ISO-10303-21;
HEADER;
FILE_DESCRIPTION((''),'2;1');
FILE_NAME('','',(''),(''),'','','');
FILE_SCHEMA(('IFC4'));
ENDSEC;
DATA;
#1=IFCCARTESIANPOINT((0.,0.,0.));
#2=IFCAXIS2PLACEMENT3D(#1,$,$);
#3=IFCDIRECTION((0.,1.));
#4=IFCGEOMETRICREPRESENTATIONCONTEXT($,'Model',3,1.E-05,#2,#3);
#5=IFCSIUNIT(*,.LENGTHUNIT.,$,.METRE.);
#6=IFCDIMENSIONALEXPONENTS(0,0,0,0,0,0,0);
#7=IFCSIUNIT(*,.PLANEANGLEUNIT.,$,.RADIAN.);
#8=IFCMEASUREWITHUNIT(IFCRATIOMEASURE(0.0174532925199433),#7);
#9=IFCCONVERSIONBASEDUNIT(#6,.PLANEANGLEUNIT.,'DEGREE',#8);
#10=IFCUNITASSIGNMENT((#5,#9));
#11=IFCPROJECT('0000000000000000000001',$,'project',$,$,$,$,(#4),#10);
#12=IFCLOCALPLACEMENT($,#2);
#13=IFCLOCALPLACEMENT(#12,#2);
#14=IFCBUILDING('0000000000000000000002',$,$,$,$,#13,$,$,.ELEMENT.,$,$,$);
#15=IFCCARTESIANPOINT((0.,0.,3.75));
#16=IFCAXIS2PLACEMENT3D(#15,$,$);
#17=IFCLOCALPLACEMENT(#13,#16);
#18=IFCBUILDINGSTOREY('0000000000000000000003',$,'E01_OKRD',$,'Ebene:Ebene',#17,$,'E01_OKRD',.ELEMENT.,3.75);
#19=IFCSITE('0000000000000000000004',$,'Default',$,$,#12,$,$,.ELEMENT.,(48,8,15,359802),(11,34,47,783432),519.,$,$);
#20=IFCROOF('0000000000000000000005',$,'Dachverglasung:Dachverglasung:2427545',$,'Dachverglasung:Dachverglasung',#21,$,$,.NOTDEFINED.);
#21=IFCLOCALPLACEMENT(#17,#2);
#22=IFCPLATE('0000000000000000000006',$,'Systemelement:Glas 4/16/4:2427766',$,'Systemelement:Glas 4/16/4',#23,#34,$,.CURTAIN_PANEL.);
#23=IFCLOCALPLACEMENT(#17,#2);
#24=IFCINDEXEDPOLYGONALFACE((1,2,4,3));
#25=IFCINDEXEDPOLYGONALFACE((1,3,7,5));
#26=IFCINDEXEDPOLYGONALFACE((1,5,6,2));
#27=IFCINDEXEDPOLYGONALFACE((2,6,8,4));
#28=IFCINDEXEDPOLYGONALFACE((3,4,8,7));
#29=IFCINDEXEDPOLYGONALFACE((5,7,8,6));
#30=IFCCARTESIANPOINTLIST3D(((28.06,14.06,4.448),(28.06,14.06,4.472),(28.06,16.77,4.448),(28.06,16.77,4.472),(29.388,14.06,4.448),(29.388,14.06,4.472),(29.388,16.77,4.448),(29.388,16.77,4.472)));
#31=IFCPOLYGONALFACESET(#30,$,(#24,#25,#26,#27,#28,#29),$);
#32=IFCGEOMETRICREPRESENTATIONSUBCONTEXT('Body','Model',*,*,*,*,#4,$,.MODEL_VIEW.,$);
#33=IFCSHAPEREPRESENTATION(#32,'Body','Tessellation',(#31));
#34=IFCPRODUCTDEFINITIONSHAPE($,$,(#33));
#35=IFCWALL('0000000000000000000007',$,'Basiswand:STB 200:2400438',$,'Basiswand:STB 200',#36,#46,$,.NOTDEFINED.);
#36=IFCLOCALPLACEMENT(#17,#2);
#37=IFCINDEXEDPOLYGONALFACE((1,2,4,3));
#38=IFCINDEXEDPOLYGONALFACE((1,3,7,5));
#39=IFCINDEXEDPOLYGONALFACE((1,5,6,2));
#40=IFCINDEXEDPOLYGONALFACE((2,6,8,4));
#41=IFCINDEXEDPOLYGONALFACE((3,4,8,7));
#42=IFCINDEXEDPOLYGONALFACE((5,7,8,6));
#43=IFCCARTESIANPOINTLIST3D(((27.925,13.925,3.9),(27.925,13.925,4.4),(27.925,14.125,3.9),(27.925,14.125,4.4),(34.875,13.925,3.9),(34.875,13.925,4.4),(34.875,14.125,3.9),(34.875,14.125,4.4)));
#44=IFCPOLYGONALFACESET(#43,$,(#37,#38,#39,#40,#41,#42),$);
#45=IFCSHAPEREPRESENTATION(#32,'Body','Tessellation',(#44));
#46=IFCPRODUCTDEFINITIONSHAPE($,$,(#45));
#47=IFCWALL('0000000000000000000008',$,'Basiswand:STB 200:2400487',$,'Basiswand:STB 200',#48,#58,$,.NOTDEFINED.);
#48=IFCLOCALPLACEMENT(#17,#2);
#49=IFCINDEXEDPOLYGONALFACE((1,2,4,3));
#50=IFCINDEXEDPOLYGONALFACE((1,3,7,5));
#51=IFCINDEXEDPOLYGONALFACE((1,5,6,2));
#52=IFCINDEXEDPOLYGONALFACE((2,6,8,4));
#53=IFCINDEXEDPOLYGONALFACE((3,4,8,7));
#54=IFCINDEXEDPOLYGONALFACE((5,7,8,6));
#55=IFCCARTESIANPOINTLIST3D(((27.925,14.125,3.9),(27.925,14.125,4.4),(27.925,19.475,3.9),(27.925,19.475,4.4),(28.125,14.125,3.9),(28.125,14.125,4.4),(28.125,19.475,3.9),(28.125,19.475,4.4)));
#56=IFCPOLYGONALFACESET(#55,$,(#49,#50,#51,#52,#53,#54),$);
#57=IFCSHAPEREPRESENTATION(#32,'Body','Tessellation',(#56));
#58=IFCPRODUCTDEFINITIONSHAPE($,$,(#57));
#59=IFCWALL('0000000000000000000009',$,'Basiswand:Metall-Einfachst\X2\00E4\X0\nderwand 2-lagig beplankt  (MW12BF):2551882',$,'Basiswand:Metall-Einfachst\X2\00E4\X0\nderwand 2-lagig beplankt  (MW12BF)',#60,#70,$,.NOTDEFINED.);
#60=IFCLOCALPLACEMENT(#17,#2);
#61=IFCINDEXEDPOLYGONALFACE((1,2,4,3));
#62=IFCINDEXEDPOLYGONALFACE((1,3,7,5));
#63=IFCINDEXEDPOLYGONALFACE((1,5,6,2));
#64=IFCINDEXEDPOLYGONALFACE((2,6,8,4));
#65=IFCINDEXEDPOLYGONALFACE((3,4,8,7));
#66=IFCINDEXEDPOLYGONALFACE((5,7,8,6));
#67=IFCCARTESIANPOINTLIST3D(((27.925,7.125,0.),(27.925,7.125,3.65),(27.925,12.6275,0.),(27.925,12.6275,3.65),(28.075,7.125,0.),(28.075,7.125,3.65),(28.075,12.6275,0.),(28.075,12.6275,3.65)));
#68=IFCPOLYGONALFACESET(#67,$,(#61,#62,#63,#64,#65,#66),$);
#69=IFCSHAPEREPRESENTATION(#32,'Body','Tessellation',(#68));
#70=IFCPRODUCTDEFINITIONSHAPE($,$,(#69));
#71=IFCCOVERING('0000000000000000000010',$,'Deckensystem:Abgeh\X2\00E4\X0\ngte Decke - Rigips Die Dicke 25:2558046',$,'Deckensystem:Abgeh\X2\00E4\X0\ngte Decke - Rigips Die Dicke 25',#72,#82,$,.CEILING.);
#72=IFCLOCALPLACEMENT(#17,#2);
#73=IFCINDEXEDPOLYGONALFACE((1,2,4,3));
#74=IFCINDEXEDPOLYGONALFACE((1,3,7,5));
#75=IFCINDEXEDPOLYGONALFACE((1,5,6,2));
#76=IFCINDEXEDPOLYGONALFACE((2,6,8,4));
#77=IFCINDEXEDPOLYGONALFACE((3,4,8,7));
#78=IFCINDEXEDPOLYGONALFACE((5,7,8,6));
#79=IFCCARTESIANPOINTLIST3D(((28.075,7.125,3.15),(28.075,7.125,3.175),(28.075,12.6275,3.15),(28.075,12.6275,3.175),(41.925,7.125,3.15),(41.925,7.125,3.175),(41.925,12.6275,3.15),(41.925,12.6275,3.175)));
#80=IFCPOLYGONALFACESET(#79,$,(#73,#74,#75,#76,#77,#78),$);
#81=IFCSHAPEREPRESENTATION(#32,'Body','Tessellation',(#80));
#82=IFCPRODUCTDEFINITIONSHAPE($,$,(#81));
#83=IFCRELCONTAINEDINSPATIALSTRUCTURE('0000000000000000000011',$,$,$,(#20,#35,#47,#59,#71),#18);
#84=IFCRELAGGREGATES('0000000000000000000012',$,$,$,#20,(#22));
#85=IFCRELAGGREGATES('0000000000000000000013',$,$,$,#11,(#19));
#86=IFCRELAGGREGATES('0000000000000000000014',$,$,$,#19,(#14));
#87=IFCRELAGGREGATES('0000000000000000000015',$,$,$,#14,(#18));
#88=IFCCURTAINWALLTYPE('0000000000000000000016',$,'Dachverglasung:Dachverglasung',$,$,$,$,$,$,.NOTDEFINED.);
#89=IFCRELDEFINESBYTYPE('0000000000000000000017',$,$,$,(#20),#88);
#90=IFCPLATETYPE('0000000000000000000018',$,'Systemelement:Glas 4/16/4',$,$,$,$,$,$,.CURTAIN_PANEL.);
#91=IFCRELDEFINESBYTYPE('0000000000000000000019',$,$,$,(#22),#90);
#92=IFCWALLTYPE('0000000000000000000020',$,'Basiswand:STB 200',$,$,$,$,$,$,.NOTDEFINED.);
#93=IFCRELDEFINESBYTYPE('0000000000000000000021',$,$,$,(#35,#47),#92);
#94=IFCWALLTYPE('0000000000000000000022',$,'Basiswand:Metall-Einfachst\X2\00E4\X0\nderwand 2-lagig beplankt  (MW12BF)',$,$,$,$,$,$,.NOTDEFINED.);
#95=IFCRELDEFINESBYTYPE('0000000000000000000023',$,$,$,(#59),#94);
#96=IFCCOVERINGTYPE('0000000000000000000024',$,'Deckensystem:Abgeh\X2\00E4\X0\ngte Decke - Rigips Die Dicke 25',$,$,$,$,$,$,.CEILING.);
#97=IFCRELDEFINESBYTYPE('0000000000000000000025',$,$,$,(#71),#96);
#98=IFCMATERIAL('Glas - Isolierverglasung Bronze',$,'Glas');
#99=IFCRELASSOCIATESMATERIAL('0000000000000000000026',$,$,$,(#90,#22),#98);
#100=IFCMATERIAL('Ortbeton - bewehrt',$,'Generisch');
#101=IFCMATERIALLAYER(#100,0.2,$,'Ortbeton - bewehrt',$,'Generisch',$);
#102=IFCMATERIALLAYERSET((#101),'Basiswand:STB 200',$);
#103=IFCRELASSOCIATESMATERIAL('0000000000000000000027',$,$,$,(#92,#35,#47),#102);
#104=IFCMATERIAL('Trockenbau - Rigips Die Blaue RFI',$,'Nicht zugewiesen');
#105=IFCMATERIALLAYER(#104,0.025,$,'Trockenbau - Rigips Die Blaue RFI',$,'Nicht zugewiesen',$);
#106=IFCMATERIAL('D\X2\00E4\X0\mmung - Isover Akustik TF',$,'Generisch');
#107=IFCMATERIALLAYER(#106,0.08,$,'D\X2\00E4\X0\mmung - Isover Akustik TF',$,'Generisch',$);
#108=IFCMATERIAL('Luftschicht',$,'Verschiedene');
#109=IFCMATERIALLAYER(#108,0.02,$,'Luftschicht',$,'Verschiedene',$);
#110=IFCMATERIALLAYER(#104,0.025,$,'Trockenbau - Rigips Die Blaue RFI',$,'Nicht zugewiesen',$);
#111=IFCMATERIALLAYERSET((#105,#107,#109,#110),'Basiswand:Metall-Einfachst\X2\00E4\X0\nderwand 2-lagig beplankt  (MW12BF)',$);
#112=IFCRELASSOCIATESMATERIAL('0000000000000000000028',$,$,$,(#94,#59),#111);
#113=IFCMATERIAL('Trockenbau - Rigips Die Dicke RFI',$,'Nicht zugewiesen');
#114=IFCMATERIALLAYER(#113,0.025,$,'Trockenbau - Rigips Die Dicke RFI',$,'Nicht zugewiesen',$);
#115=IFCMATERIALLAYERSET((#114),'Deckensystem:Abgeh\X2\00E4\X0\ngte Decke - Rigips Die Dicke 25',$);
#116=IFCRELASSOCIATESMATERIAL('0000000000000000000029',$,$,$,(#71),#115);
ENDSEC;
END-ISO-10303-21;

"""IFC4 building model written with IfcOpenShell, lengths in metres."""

from ifc_helpers import new_model, entity, si_unit, converted_unit, direction, frame, frame_2d, origin, origin_2d_with_axis, place, context, subcontext, project, spatial, rectangle, extrude, shape, source, transform, mapped, material, layer, layer_set, layer_usage, type_object, type_shapes, element, aggregate, save


model = new_model("IFC4")

# Units and contexts
model_context = context("Model", 3, precision=1e-05, world=origin(), true_north=direction((0.0, 1.0)))
body_context = subcontext(model_context, "Body", "Model", "MODEL_VIEW")
footprint_context = subcontext(model_context, "FootPrint", "Model", "MODEL_VIEW")
ifc_project = project(units=[si_unit("LENGTHUNIT", "METRE"), converted_unit("PLANEANGLEUNIT", "DEGREE", entity("IfcRatioMeasure", 0.0174532925199433), si_unit("PLANEANGLEUNIT", "RADIAN"), dimensions=[0, 0, 0, 0, 0, 0, 0])], contexts=[model_context])

# Site, building, storey
site_placement = place(None, frame((0.0, 0.0, 0.0)))
site = spatial("IfcSite", under=ifc_project, at=site_placement, Name="Default", CompositionType="ELEMENT", RefLatitude=(48, 8, 15, 359802), RefLongitude=(11, 34, 47, 783432), RefElevation=519.0)
building_placement = place(site_placement, origin())
building = spatial("IfcBuilding", under=site, at=building_placement, CompositionType="ELEMENT")
storey_placement = place(building_placement, frame((0.0, 0.0, 3.75)))
storey = spatial("IfcBuildingStorey", under=building, at=storey_placement, Name="E01_OKRD", ObjectType="Ebene:Ebene", LongName="E01_OKRD", CompositionType="ELEMENT", Elevation=3.75)

# Shared definitions
ifc_material_1 = material(Name="Ortbeton - bewehrt", Category="Generisch")

# Roof, plate
curtain_wall_type = type_object("IfcCurtainWallType", Name="Dachverglasung:Dachverglasung", PredefinedType="NOTDEFINED")
roof_placement = place(storey_placement, frame((0.0, 0.0, -3.75)))
roof = element("IfcRoof", 1, at=roof_placement, inside=storey, type_object=curtain_wall_type, Name="Dachverglasung:Dachverglasung:2427545", ObjectType="Dachverglasung:Dachverglasung", PredefinedType="NOTDEFINED")
ifc_material_2 = material(Name="Glas - Isolierverglasung Bronze", Category="Glas")
plate_type = type_object("IfcPlateType", Name="Systemelement:Glas 4/16/4", PredefinedType="CURTAIN_PANEL", material=ifc_material_2)
shared_shape_1 = source(origin(), body_context, "Body", "SweptSolid", [
    extrude(rectangle(XDim=0.024, YDim=2.71, at=origin_2d_with_axis()), frame((0.0, 0.0, 0.0), z_axis=(0.0, 0.0, 1.0), x_axis=(0.0, 1.0, 0.0)), (0.0, 0.0, 1.0), 1.328),
])
cartesian_point = entity("IfcCartesianPoint", [1.355, -0.012])
shared_shape_2 = source(origin(), footprint_context, "FootPrint", "Curve2D", [
    entity("IfcPolyline", [cartesian_point, entity("IfcCartesianPoint", [1.355, 0.012]), entity("IfcCartesianPoint", [-1.355, 0.012]), entity("IfcCartesianPoint", [-1.355, -0.012]), cartesian_point]),
])
type_shapes(plate_type, [shared_shape_1, shared_shape_2])
plate_1_placement = place(roof_placement, frame((29.388, 15.415, 8.21), z_axis=(-1.0, 0.0, 0.0), x_axis=(0.0, 1.0, 0.0)))
plate_1 = element("IfcPlate", 2, at=plate_1_placement, type_object=plate_type, material=ifc_material_2, Name="Systemelement:Glas 4/16/4:2427766", ObjectType="Systemelement:Glas 4/16/4", PredefinedType="CURTAIN_PANEL", shapes=[
    shape(body_context, "Body", "MappedRepresentation", [mapped(shared_shape_1, transform((0.0, 0.0, 0.0), scale=1.0))]),
    shape(body_context, "Body", "MappedRepresentation", [mapped(shared_shape_2, transform((0.0, 0.0, 0.0), scale=1.0))]),
])
aggregate(roof, [plate_1])

# Walls
ifc_layer_1 = layer(ifc_material_1, 0.2, Name="Ortbeton - bewehrt", Category="Generisch")
ifc_layer_set_1 = layer_set([ifc_layer_1], Name="Basiswand:STB 200")
ifc_layer_usage_1 = layer_usage(ifc_layer_set_1, "AXIS2", "NEGATIVE", 0.1)
wall_type_1 = type_object("IfcWallType", Name="Basiswand:STB 200", PredefinedType="NOTDEFINED", material=ifc_layer_set_1)
wall_1_placement = place(storey_placement, frame((34.875, 14.025, 3.9), z_axis=(0.0, 0.0, 1.0), x_axis=(-1.0, 0.0, 0.0)))
element("IfcWall", 3, at=wall_1_placement, inside=storey, type_object=wall_type_1, material=ifc_layer_usage_1, Name="Basiswand:STB 200:2400438", ObjectType="Basiswand:STB 200", PredefinedType="NOTDEFINED", context=body_context, shape_type="SweptSolid", body=[
    extrude(rectangle(XDim=6.95, YDim=0.2, at=frame_2d((3.475, 0.0), x_axis=(-1.0, 0.0))), origin(), (0.0, 0.0, 1.0), 0.5),
])
ifc_layer_usage_2 = layer_usage(ifc_layer_set_1, "AXIS2", "NEGATIVE", 0.1)
wall_2_placement = place(storey_placement, frame((28.025, 14.125, 3.9), z_axis=(0.0, 0.0, 1.0), x_axis=(0.0, 1.0, 0.0)))
element("IfcWall", 4, at=wall_2_placement, inside=storey, type_object=wall_type_1, material=ifc_layer_usage_2, Name="Basiswand:STB 200:2400487", ObjectType="Basiswand:STB 200", PredefinedType="NOTDEFINED", context=body_context, shape_type="SweptSolid", body=[
    extrude(rectangle(XDim=5.35, YDim=0.2, at=frame_2d((2.675, 0.0), x_axis=(-1.0, 0.0))), origin(), (0.0, 0.0, 1.0), 0.5),
])
ifc_material_3 = material(Name="Trockenbau - Rigips Die Blaue RFI", Category="Nicht zugewiesen")
ifc_layer_2 = layer(ifc_material_3, 0.025, Name="Trockenbau - Rigips Die Blaue RFI", Category="Nicht zugewiesen")
ifc_material_4 = material(Name="Dämmung - Isover Akustik TF", Category="Generisch")
ifc_layer_3 = layer(ifc_material_4, 0.08, Name="Dämmung - Isover Akustik TF", Category="Generisch")
ifc_material_5 = material(Name="Luftschicht", Category="Verschiedene")
ifc_layer_4 = layer(ifc_material_5, 0.02, Name="Luftschicht", Category="Verschiedene")
ifc_layer_5 = layer(ifc_material_3, 0.025, Name="Trockenbau - Rigips Die Blaue RFI", Category="Nicht zugewiesen")
ifc_layer_set_2 = layer_set([ifc_layer_2, ifc_layer_3, ifc_layer_4, ifc_layer_5], Name="Basiswand:Metall-Einfachständerwand 2-lagig beplankt  (MW12BF)")
ifc_layer_usage_3 = layer_usage(ifc_layer_set_2, "AXIS2", "NEGATIVE", 0.075)
wall_type_2 = type_object("IfcWallType", Name="Basiswand:Metall-Einfachständerwand 2-lagig beplankt  (MW12BF)", PredefinedType="NOTDEFINED", material=ifc_layer_set_2)
wall_3_placement = place(storey_placement, frame((28.0, 7.125, 0.0), z_axis=(0.0, 0.0, 1.0), x_axis=(0.0, 1.0, 0.0)))
element("IfcWall", 5, at=wall_3_placement, inside=storey, type_object=wall_type_2, material=ifc_layer_usage_3, Name="Basiswand:Metall-Einfachständerwand 2-lagig beplankt  (MW12BF):2551882", ObjectType="Basiswand:Metall-Einfachständerwand 2-lagig beplankt  (MW12BF)", PredefinedType="NOTDEFINED", context=body_context, shape_type="SweptSolid", body=[
    extrude(rectangle(XDim=5.5025, YDim=0.15, at=frame_2d((2.7513, 0.0), x_axis=(-1.0, 0.0))), origin(), (0.0, 0.0, 1.0), 3.65),
])

# Covering
ifc_material_6 = material(Name="Trockenbau - Rigips Die Dicke RFI", Category="Nicht zugewiesen")
ifc_layer_6 = layer(ifc_material_6, 0.025, Name="Trockenbau - Rigips Die Dicke RFI", Category="Nicht zugewiesen")
ifc_layer_set_3 = layer_set([ifc_layer_6], Name="Deckensystem:Abgehängte Decke - Rigips Die Dicke 25")
ifc_layer_usage_4 = layer_usage(ifc_layer_set_3, "AXIS3", "POSITIVE", 0.0)
covering_type = type_object("IfcCoveringType", Name="Deckensystem:Abgehängte Decke - Rigips Die Dicke 25", PredefinedType="CEILING")
covering_placement = place(storey_placement, frame((28.075, 7.125, 3.15)))
element("IfcCovering", 6, at=covering_placement, inside=storey, type_object=covering_type, material=ifc_layer_usage_4, Name="Deckensystem:Abgehängte Decke - Rigips Die Dicke 25:2558046", ObjectType="Deckensystem:Abgehängte Decke - Rigips Die Dicke 25", PredefinedType="CEILING", context=body_context, shape_type="SweptSolid", body=[
    extrude(rectangle(XDim=13.85, YDim=5.5025, at=origin_2d_with_axis()), frame((6.925, 2.7512, 0.0), z_axis=(0.0, 0.0, 1.0), x_axis=(-1.0, 0.0, 0.0)), (0.0, 0.0, 1.0), 0.025),
])

save(model, "model.ifc")
